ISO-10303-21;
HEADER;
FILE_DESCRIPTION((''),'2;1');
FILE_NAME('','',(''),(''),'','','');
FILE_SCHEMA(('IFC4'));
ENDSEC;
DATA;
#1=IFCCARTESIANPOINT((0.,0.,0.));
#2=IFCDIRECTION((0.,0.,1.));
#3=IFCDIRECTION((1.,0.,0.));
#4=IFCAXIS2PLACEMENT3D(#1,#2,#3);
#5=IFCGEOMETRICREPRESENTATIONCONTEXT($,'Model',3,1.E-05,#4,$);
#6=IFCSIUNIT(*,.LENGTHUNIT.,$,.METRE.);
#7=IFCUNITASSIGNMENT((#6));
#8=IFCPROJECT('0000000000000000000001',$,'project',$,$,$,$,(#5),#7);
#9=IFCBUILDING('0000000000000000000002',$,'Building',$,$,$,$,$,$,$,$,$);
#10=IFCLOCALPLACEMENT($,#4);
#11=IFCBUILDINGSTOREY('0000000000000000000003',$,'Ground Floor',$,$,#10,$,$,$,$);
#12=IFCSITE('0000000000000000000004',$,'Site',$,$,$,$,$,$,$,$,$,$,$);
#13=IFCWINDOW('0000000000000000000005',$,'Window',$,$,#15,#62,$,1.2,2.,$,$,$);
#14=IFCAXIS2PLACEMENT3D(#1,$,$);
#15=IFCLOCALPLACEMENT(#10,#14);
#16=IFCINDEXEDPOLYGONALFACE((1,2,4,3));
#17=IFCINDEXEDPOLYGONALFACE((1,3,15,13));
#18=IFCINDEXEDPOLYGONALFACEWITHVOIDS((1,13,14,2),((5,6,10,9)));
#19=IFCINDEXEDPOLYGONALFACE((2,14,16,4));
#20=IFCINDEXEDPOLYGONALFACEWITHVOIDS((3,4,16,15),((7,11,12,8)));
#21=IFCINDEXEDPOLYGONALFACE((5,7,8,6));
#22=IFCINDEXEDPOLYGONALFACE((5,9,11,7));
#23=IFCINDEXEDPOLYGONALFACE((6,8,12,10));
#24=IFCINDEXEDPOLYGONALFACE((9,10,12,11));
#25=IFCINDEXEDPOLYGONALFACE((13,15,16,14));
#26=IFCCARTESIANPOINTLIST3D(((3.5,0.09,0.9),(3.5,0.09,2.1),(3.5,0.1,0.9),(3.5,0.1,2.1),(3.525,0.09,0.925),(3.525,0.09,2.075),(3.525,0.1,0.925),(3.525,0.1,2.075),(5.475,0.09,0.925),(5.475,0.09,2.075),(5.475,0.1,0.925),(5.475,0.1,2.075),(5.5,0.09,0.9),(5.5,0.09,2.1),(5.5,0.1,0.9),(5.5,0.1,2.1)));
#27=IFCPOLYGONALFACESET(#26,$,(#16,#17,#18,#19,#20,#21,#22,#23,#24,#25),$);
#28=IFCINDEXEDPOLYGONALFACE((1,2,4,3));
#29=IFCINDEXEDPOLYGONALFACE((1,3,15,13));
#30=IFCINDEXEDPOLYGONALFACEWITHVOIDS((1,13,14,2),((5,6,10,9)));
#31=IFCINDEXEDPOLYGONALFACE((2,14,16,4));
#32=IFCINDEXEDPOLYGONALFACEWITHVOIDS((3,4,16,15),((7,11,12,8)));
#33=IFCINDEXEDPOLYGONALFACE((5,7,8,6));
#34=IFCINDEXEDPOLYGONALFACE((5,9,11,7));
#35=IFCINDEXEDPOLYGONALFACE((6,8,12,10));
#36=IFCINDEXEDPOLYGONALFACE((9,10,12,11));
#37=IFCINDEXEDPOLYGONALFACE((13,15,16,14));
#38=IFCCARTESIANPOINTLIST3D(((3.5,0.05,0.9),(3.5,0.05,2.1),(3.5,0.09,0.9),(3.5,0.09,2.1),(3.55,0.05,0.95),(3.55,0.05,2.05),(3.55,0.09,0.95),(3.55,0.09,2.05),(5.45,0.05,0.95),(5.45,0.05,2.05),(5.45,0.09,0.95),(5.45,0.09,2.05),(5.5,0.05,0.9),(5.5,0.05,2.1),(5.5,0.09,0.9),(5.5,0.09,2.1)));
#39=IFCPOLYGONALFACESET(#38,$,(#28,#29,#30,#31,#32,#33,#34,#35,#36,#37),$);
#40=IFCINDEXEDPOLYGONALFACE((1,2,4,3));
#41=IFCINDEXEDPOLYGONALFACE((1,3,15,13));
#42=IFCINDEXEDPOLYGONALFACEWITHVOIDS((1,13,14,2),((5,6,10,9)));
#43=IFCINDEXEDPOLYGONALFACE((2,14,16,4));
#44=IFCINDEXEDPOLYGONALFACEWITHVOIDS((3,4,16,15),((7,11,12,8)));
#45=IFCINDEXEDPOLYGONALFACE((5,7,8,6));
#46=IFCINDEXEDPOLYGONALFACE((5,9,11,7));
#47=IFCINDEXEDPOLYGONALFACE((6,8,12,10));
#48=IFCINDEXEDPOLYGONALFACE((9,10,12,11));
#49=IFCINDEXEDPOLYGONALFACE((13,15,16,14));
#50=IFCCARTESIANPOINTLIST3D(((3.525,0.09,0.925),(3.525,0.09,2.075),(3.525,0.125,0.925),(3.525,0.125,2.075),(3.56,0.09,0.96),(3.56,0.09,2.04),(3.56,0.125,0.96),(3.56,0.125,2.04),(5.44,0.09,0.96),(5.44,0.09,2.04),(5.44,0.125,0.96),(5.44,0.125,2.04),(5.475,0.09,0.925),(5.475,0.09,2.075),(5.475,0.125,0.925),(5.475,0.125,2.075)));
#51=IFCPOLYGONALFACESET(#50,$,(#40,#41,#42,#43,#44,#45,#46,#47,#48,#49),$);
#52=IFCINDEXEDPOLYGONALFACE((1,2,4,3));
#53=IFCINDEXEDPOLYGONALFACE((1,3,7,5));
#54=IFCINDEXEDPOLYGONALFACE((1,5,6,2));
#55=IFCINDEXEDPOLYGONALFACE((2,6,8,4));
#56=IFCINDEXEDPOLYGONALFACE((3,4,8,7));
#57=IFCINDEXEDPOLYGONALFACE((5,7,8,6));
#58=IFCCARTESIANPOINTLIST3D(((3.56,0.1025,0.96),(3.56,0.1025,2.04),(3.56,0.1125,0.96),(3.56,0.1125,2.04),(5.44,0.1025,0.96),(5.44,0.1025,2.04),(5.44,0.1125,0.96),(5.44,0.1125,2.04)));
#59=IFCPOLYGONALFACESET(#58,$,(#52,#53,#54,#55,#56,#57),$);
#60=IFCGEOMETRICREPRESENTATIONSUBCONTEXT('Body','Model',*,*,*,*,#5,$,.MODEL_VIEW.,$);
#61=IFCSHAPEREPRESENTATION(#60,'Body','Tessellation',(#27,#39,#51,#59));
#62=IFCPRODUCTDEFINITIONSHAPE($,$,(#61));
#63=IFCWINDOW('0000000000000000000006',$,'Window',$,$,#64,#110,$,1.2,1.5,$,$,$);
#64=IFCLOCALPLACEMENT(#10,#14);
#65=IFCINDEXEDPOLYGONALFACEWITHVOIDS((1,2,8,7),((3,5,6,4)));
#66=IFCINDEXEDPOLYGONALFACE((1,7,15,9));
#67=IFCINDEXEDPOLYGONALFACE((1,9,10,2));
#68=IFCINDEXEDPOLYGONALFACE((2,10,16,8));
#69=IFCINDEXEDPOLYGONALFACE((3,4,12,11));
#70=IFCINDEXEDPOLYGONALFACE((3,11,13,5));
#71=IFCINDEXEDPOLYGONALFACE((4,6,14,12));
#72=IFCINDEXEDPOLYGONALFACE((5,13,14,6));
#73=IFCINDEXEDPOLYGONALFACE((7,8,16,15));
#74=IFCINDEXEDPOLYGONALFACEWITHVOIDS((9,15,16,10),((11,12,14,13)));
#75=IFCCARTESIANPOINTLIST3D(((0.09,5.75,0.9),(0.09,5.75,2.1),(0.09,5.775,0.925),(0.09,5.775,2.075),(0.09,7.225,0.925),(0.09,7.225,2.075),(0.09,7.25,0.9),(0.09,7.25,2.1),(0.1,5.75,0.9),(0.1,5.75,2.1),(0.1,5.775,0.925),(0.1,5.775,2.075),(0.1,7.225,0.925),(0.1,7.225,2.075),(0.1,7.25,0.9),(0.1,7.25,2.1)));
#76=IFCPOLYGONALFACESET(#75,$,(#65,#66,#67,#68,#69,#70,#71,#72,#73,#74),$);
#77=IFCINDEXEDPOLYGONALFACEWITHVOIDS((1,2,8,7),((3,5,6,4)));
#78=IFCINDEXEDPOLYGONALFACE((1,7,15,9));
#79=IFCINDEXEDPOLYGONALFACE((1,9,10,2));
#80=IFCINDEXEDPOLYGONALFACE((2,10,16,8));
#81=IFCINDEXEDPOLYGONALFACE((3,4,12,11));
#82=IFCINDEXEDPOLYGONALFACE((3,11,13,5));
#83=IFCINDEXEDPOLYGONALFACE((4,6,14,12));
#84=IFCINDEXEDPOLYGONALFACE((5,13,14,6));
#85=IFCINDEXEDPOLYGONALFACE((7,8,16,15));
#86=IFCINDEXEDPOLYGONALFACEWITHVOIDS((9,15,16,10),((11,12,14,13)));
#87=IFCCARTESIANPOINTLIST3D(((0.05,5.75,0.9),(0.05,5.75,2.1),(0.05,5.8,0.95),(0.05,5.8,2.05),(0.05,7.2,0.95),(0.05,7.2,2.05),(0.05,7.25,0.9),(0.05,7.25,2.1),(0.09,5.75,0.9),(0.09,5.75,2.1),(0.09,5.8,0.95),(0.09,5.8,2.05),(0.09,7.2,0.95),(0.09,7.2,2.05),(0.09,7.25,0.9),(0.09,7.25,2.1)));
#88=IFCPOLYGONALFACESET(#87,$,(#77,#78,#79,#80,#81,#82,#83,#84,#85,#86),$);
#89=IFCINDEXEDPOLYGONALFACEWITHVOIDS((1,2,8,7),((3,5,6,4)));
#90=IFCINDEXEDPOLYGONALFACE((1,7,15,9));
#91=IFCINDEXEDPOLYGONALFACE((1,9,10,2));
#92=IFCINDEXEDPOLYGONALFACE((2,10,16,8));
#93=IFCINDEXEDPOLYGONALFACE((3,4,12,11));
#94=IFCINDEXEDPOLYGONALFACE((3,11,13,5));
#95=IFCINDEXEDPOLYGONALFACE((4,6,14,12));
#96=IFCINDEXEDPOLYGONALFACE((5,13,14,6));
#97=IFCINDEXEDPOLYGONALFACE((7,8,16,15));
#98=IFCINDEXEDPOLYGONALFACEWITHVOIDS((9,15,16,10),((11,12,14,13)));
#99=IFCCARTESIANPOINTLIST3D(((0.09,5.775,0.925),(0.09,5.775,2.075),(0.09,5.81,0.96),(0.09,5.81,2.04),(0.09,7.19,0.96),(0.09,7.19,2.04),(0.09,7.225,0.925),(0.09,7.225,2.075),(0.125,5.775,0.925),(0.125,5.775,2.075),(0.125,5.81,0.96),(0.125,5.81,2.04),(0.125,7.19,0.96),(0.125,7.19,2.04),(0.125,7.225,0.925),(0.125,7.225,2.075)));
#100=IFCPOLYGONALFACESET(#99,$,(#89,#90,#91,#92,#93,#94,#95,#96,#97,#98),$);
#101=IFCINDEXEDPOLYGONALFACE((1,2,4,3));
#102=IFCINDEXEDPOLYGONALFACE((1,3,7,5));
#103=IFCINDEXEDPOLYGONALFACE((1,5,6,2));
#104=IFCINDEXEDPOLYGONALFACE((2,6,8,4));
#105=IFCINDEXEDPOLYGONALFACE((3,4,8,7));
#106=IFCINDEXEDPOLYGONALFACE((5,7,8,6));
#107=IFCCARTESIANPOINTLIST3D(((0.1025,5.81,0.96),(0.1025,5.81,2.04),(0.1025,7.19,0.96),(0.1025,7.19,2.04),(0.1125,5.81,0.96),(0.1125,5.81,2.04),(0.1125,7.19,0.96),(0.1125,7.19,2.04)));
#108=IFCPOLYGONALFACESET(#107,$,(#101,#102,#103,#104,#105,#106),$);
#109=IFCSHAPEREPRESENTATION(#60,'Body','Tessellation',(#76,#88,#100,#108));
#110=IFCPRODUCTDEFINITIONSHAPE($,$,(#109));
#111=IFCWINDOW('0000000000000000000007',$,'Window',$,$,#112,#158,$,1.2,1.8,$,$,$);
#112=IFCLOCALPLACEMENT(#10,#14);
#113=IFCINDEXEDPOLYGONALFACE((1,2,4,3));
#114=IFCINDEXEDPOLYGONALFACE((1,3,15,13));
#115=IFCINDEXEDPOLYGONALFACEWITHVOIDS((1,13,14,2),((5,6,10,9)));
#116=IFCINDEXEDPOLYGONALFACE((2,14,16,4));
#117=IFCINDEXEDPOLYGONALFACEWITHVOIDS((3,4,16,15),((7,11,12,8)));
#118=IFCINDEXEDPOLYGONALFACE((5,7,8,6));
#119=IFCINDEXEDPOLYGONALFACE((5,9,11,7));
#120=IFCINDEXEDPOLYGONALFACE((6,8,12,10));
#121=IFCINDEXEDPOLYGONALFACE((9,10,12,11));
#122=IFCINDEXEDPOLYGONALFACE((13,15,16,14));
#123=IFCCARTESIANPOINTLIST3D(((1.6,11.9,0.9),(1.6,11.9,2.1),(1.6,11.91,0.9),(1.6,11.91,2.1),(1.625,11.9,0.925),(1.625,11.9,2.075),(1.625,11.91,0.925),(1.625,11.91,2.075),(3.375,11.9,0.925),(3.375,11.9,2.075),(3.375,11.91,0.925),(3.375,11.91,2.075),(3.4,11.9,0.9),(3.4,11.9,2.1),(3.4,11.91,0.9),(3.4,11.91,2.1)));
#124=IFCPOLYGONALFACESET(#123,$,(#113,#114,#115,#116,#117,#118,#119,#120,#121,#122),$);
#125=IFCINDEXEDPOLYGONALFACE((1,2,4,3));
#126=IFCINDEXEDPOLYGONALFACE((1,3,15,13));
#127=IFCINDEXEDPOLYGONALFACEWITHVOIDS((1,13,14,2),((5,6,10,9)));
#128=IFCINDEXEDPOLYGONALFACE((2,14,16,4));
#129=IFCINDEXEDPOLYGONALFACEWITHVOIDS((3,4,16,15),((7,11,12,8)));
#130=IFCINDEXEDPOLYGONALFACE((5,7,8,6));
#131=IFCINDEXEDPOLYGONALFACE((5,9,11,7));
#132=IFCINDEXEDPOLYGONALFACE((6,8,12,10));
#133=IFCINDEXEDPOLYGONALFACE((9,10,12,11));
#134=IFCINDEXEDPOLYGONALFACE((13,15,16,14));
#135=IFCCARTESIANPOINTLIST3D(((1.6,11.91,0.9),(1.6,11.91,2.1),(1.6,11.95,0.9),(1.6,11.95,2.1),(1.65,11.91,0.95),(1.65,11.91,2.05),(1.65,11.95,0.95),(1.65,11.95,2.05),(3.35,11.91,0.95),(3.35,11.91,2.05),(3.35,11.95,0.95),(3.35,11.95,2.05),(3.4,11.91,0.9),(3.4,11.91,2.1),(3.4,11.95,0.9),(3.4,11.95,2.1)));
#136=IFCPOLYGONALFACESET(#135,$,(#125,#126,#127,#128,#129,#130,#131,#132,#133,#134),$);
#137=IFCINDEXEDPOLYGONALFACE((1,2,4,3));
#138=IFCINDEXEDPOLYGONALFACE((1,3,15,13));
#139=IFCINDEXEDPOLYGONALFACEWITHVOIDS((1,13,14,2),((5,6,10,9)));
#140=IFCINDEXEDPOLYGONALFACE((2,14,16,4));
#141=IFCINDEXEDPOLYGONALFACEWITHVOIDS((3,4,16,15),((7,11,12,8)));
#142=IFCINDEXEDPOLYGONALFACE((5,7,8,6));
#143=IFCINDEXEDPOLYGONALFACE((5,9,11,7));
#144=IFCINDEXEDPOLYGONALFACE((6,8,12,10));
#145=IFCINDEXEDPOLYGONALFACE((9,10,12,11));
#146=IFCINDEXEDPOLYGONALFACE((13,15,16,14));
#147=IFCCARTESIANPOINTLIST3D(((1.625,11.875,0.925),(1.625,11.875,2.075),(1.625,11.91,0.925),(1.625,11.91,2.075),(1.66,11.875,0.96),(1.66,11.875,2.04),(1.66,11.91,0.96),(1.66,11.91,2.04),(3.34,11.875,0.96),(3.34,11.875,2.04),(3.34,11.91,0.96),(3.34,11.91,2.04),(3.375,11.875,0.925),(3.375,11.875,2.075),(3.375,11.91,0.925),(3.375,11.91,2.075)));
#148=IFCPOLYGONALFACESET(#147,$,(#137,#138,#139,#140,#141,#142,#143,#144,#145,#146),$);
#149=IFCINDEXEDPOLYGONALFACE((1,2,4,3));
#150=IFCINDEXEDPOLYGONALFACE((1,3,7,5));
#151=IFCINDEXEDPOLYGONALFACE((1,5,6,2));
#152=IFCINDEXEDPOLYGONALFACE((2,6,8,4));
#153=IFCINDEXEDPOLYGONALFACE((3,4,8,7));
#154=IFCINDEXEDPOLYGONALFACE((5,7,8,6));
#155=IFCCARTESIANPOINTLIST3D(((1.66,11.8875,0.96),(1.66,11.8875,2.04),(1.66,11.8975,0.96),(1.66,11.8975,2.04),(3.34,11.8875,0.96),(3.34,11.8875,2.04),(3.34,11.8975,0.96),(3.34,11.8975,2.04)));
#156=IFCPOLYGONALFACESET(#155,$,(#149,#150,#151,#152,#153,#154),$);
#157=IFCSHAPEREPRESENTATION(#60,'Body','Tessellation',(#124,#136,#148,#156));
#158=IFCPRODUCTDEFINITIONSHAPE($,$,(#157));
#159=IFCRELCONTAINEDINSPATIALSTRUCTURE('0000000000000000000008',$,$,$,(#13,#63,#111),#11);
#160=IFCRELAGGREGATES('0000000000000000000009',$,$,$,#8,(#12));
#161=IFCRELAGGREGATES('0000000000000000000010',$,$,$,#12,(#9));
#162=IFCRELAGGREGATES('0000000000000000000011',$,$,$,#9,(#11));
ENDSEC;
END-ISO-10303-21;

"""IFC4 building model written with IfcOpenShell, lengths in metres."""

from ifc_helpers import new_model, si_unit, frame, origin_with_axes, place, context, subcontext, project, spatial, line, indexed_curve, outline, extrude, element, save


model = new_model("IFC4")

# Units and contexts
model_context = context("Model", 3, precision=1e-05, world=origin_with_axes())
body_context = subcontext(model_context, "Body", "Model", "MODEL_VIEW")
ifc_project = project(units=[si_unit("LENGTHUNIT", "METRE")], contexts=[model_context])

# Site, building, storey
site = spatial("IfcSite", under=ifc_project, Name="Site")
building = spatial("IfcBuilding", under=site, Name="Building")
storey_placement = place(None, origin_with_axes())
storey = spatial("IfcBuildingStorey", under=building, at=storey_placement, Name="Ground Floor")

# Windows
window_1_placement = place(storey_placement, frame((3.5, 0.0, 0.9), z_axis=(0.0, 0.0, 1.0), x_axis=(1.0, 0.0, 0.0)))
element("IfcWindow", 1, at=window_1_placement, inside=storey, Name="Window", OverallHeight=1.2, OverallWidth=2.0, context=body_context, shape_type="SweptSolid", body=[
    extrude(outline(indexed_curve([(0.0, 0.0), (2.0, 0.0), (2.0, 1.2), (0.0, 1.2)], segments=[line(1, 2, 3, 4, 1)]), holes=[indexed_curve([(0.025, 0.025), (1.975, 0.025), (1.975, 1.175), (0.025, 1.175)], segments=[line(1, 2, 3, 4, 1)])]), frame((0.0, 0.09, 0.0), z_axis=(0.0, -1.0, 0.0), x_axis=(1.0, 0.0, 0.0)), (0.0, 0.0, -1.0), 0.01),
    extrude(outline(indexed_curve([(0.0, 0.0), (2.0, 0.0), (2.0, 1.2), (0.0, 1.2)], segments=[line(1, 2, 3, 4, 1)]), holes=[indexed_curve([(0.05, 0.05), (1.95, 0.05), (1.95, 1.15), (0.05, 1.15)], segments=[line(1, 2, 3, 4, 1)])]), frame((0.0, 0.05, 0.0), z_axis=(0.0, -1.0, 0.0), x_axis=(1.0, 0.0, 0.0)), (0.0, 0.0, -1.0), 0.04),
    extrude(outline(indexed_curve([(0.0, 0.0), (1.95, 0.0), (1.95, 1.15), (0.0, 1.15)], segments=[line(1, 2, 3, 4, 1)]), holes=[indexed_curve([(0.035, 0.035), (1.915, 0.035), (1.915, 1.115), (0.035, 1.115)], segments=[line(1, 2, 3, 4, 1)])]), frame((0.025, 0.09, 0.025), z_axis=(0.0, -1.0, 0.0), x_axis=(1.0, 0.0, 0.0)), (0.0, 0.0, -1.0), 0.035),
    extrude(outline(indexed_curve([(0.035, 0.035), (1.915, 0.035), (1.915, 1.115), (0.035, 1.115)], segments=[line(1, 2, 3, 4, 1)])), frame((0.025, 0.1025, 0.025), z_axis=(0.0, -1.0, 0.0), x_axis=(1.0, 0.0, 0.0)), (0.0, 0.0, -1.0), 0.01),
])
window_2_placement = place(storey_placement, frame((0.0, 7.25, 0.9), z_axis=(0.0, 0.0, 1.0), x_axis=(0.0, -1.0, 0.0)))
element("IfcWindow", 2, at=window_2_placement, inside=storey, Name="Window", OverallHeight=1.2, OverallWidth=1.5, context=body_context, shape_type="SweptSolid", body=[
    extrude(outline(indexed_curve([(0.0, 0.0), (1.5, 0.0), (1.5, 1.2), (0.0, 1.2)], segments=[line(1, 2, 3, 4, 1)]), holes=[indexed_curve([(0.025, 0.025), (1.475, 0.025), (1.475, 1.175), (0.025, 1.175)], segments=[line(1, 2, 3, 4, 1)])]), frame((0.0, 0.09, 0.0), z_axis=(0.0, -1.0, 0.0), x_axis=(1.0, 0.0, 0.0)), (0.0, 0.0, -1.0), 0.01),
    extrude(outline(indexed_curve([(0.0, 0.0), (1.5, 0.0), (1.5, 1.2), (0.0, 1.2)], segments=[line(1, 2, 3, 4, 1)]), holes=[indexed_curve([(0.05, 0.05), (1.45, 0.05), (1.45, 1.15), (0.05, 1.15)], segments=[line(1, 2, 3, 4, 1)])]), frame((0.0, 0.05, 0.0), z_axis=(0.0, -1.0, 0.0), x_axis=(1.0, 0.0, 0.0)), (0.0, 0.0, -1.0), 0.04),
    extrude(outline(indexed_curve([(0.0, 0.0), (1.45, 0.0), (1.45, 1.15), (0.0, 1.15)], segments=[line(1, 2, 3, 4, 1)]), holes=[indexed_curve([(0.035, 0.035), (1.415, 0.035), (1.415, 1.115), (0.035, 1.115)], segments=[line(1, 2, 3, 4, 1)])]), frame((0.025, 0.09, 0.025), z_axis=(0.0, -1.0, 0.0), x_axis=(1.0, 0.0, 0.0)), (0.0, 0.0, -1.0), 0.035),
    extrude(outline(indexed_curve([(0.035, 0.035), (1.415, 0.035), (1.415, 1.115), (0.035, 1.115)], segments=[line(1, 2, 3, 4, 1)])), frame((0.025, 0.1025, 0.025), z_axis=(0.0, -1.0, 0.0), x_axis=(1.0, 0.0, 0.0)), (0.0, 0.0, -1.0), 0.01),
])
window_3_placement = place(storey_placement, frame((3.4, 12.0, 0.9), z_axis=(0.0, 0.0, 1.0), x_axis=(-1.0, 0.0, 0.0)))
element("IfcWindow", 3, at=window_3_placement, inside=storey, Name="Window", OverallHeight=1.2, OverallWidth=1.8, context=body_context, shape_type="SweptSolid", body=[
    extrude(outline(indexed_curve([(0.0, 0.0), (1.8, 0.0), (1.8, 1.2), (0.0, 1.2)], segments=[line(1, 2, 3, 4, 1)]), holes=[indexed_curve([(0.025, 0.025), (1.775, 0.025), (1.775, 1.175), (0.025, 1.175)], segments=[line(1, 2, 3, 4, 1)])]), frame((0.0, 0.09, 0.0), z_axis=(0.0, -1.0, 0.0), x_axis=(1.0, 0.0, 0.0)), (0.0, 0.0, -1.0), 0.01),
    extrude(outline(indexed_curve([(0.0, 0.0), (1.8, 0.0), (1.8, 1.2), (0.0, 1.2)], segments=[line(1, 2, 3, 4, 1)]), holes=[indexed_curve([(0.05, 0.05), (1.75, 0.05), (1.75, 1.15), (0.05, 1.15)], segments=[line(1, 2, 3, 4, 1)])]), frame((0.0, 0.05, 0.0), z_axis=(0.0, -1.0, 0.0), x_axis=(1.0, 0.0, 0.0)), (0.0, 0.0, -1.0), 0.04),
    extrude(outline(indexed_curve([(0.0, 0.0), (1.75, 0.0), (1.75, 1.15), (0.0, 1.15)], segments=[line(1, 2, 3, 4, 1)]), holes=[indexed_curve([(0.035, 0.035), (1.715, 0.035), (1.715, 1.115), (0.035, 1.115)], segments=[line(1, 2, 3, 4, 1)])]), frame((0.025, 0.09, 0.025), z_axis=(0.0, -1.0, 0.0), x_axis=(1.0, 0.0, 0.0)), (0.0, 0.0, -1.0), 0.035),
    extrude(outline(indexed_curve([(0.035, 0.035), (1.715, 0.035), (1.715, 1.115), (0.035, 1.115)], segments=[line(1, 2, 3, 4, 1)])), frame((0.025, 0.1025, 0.025), z_axis=(0.0, -1.0, 0.0), x_axis=(1.0, 0.0, 0.0)), (0.0, 0.0, -1.0), 0.01),
])

save(model, "model.ifc")
